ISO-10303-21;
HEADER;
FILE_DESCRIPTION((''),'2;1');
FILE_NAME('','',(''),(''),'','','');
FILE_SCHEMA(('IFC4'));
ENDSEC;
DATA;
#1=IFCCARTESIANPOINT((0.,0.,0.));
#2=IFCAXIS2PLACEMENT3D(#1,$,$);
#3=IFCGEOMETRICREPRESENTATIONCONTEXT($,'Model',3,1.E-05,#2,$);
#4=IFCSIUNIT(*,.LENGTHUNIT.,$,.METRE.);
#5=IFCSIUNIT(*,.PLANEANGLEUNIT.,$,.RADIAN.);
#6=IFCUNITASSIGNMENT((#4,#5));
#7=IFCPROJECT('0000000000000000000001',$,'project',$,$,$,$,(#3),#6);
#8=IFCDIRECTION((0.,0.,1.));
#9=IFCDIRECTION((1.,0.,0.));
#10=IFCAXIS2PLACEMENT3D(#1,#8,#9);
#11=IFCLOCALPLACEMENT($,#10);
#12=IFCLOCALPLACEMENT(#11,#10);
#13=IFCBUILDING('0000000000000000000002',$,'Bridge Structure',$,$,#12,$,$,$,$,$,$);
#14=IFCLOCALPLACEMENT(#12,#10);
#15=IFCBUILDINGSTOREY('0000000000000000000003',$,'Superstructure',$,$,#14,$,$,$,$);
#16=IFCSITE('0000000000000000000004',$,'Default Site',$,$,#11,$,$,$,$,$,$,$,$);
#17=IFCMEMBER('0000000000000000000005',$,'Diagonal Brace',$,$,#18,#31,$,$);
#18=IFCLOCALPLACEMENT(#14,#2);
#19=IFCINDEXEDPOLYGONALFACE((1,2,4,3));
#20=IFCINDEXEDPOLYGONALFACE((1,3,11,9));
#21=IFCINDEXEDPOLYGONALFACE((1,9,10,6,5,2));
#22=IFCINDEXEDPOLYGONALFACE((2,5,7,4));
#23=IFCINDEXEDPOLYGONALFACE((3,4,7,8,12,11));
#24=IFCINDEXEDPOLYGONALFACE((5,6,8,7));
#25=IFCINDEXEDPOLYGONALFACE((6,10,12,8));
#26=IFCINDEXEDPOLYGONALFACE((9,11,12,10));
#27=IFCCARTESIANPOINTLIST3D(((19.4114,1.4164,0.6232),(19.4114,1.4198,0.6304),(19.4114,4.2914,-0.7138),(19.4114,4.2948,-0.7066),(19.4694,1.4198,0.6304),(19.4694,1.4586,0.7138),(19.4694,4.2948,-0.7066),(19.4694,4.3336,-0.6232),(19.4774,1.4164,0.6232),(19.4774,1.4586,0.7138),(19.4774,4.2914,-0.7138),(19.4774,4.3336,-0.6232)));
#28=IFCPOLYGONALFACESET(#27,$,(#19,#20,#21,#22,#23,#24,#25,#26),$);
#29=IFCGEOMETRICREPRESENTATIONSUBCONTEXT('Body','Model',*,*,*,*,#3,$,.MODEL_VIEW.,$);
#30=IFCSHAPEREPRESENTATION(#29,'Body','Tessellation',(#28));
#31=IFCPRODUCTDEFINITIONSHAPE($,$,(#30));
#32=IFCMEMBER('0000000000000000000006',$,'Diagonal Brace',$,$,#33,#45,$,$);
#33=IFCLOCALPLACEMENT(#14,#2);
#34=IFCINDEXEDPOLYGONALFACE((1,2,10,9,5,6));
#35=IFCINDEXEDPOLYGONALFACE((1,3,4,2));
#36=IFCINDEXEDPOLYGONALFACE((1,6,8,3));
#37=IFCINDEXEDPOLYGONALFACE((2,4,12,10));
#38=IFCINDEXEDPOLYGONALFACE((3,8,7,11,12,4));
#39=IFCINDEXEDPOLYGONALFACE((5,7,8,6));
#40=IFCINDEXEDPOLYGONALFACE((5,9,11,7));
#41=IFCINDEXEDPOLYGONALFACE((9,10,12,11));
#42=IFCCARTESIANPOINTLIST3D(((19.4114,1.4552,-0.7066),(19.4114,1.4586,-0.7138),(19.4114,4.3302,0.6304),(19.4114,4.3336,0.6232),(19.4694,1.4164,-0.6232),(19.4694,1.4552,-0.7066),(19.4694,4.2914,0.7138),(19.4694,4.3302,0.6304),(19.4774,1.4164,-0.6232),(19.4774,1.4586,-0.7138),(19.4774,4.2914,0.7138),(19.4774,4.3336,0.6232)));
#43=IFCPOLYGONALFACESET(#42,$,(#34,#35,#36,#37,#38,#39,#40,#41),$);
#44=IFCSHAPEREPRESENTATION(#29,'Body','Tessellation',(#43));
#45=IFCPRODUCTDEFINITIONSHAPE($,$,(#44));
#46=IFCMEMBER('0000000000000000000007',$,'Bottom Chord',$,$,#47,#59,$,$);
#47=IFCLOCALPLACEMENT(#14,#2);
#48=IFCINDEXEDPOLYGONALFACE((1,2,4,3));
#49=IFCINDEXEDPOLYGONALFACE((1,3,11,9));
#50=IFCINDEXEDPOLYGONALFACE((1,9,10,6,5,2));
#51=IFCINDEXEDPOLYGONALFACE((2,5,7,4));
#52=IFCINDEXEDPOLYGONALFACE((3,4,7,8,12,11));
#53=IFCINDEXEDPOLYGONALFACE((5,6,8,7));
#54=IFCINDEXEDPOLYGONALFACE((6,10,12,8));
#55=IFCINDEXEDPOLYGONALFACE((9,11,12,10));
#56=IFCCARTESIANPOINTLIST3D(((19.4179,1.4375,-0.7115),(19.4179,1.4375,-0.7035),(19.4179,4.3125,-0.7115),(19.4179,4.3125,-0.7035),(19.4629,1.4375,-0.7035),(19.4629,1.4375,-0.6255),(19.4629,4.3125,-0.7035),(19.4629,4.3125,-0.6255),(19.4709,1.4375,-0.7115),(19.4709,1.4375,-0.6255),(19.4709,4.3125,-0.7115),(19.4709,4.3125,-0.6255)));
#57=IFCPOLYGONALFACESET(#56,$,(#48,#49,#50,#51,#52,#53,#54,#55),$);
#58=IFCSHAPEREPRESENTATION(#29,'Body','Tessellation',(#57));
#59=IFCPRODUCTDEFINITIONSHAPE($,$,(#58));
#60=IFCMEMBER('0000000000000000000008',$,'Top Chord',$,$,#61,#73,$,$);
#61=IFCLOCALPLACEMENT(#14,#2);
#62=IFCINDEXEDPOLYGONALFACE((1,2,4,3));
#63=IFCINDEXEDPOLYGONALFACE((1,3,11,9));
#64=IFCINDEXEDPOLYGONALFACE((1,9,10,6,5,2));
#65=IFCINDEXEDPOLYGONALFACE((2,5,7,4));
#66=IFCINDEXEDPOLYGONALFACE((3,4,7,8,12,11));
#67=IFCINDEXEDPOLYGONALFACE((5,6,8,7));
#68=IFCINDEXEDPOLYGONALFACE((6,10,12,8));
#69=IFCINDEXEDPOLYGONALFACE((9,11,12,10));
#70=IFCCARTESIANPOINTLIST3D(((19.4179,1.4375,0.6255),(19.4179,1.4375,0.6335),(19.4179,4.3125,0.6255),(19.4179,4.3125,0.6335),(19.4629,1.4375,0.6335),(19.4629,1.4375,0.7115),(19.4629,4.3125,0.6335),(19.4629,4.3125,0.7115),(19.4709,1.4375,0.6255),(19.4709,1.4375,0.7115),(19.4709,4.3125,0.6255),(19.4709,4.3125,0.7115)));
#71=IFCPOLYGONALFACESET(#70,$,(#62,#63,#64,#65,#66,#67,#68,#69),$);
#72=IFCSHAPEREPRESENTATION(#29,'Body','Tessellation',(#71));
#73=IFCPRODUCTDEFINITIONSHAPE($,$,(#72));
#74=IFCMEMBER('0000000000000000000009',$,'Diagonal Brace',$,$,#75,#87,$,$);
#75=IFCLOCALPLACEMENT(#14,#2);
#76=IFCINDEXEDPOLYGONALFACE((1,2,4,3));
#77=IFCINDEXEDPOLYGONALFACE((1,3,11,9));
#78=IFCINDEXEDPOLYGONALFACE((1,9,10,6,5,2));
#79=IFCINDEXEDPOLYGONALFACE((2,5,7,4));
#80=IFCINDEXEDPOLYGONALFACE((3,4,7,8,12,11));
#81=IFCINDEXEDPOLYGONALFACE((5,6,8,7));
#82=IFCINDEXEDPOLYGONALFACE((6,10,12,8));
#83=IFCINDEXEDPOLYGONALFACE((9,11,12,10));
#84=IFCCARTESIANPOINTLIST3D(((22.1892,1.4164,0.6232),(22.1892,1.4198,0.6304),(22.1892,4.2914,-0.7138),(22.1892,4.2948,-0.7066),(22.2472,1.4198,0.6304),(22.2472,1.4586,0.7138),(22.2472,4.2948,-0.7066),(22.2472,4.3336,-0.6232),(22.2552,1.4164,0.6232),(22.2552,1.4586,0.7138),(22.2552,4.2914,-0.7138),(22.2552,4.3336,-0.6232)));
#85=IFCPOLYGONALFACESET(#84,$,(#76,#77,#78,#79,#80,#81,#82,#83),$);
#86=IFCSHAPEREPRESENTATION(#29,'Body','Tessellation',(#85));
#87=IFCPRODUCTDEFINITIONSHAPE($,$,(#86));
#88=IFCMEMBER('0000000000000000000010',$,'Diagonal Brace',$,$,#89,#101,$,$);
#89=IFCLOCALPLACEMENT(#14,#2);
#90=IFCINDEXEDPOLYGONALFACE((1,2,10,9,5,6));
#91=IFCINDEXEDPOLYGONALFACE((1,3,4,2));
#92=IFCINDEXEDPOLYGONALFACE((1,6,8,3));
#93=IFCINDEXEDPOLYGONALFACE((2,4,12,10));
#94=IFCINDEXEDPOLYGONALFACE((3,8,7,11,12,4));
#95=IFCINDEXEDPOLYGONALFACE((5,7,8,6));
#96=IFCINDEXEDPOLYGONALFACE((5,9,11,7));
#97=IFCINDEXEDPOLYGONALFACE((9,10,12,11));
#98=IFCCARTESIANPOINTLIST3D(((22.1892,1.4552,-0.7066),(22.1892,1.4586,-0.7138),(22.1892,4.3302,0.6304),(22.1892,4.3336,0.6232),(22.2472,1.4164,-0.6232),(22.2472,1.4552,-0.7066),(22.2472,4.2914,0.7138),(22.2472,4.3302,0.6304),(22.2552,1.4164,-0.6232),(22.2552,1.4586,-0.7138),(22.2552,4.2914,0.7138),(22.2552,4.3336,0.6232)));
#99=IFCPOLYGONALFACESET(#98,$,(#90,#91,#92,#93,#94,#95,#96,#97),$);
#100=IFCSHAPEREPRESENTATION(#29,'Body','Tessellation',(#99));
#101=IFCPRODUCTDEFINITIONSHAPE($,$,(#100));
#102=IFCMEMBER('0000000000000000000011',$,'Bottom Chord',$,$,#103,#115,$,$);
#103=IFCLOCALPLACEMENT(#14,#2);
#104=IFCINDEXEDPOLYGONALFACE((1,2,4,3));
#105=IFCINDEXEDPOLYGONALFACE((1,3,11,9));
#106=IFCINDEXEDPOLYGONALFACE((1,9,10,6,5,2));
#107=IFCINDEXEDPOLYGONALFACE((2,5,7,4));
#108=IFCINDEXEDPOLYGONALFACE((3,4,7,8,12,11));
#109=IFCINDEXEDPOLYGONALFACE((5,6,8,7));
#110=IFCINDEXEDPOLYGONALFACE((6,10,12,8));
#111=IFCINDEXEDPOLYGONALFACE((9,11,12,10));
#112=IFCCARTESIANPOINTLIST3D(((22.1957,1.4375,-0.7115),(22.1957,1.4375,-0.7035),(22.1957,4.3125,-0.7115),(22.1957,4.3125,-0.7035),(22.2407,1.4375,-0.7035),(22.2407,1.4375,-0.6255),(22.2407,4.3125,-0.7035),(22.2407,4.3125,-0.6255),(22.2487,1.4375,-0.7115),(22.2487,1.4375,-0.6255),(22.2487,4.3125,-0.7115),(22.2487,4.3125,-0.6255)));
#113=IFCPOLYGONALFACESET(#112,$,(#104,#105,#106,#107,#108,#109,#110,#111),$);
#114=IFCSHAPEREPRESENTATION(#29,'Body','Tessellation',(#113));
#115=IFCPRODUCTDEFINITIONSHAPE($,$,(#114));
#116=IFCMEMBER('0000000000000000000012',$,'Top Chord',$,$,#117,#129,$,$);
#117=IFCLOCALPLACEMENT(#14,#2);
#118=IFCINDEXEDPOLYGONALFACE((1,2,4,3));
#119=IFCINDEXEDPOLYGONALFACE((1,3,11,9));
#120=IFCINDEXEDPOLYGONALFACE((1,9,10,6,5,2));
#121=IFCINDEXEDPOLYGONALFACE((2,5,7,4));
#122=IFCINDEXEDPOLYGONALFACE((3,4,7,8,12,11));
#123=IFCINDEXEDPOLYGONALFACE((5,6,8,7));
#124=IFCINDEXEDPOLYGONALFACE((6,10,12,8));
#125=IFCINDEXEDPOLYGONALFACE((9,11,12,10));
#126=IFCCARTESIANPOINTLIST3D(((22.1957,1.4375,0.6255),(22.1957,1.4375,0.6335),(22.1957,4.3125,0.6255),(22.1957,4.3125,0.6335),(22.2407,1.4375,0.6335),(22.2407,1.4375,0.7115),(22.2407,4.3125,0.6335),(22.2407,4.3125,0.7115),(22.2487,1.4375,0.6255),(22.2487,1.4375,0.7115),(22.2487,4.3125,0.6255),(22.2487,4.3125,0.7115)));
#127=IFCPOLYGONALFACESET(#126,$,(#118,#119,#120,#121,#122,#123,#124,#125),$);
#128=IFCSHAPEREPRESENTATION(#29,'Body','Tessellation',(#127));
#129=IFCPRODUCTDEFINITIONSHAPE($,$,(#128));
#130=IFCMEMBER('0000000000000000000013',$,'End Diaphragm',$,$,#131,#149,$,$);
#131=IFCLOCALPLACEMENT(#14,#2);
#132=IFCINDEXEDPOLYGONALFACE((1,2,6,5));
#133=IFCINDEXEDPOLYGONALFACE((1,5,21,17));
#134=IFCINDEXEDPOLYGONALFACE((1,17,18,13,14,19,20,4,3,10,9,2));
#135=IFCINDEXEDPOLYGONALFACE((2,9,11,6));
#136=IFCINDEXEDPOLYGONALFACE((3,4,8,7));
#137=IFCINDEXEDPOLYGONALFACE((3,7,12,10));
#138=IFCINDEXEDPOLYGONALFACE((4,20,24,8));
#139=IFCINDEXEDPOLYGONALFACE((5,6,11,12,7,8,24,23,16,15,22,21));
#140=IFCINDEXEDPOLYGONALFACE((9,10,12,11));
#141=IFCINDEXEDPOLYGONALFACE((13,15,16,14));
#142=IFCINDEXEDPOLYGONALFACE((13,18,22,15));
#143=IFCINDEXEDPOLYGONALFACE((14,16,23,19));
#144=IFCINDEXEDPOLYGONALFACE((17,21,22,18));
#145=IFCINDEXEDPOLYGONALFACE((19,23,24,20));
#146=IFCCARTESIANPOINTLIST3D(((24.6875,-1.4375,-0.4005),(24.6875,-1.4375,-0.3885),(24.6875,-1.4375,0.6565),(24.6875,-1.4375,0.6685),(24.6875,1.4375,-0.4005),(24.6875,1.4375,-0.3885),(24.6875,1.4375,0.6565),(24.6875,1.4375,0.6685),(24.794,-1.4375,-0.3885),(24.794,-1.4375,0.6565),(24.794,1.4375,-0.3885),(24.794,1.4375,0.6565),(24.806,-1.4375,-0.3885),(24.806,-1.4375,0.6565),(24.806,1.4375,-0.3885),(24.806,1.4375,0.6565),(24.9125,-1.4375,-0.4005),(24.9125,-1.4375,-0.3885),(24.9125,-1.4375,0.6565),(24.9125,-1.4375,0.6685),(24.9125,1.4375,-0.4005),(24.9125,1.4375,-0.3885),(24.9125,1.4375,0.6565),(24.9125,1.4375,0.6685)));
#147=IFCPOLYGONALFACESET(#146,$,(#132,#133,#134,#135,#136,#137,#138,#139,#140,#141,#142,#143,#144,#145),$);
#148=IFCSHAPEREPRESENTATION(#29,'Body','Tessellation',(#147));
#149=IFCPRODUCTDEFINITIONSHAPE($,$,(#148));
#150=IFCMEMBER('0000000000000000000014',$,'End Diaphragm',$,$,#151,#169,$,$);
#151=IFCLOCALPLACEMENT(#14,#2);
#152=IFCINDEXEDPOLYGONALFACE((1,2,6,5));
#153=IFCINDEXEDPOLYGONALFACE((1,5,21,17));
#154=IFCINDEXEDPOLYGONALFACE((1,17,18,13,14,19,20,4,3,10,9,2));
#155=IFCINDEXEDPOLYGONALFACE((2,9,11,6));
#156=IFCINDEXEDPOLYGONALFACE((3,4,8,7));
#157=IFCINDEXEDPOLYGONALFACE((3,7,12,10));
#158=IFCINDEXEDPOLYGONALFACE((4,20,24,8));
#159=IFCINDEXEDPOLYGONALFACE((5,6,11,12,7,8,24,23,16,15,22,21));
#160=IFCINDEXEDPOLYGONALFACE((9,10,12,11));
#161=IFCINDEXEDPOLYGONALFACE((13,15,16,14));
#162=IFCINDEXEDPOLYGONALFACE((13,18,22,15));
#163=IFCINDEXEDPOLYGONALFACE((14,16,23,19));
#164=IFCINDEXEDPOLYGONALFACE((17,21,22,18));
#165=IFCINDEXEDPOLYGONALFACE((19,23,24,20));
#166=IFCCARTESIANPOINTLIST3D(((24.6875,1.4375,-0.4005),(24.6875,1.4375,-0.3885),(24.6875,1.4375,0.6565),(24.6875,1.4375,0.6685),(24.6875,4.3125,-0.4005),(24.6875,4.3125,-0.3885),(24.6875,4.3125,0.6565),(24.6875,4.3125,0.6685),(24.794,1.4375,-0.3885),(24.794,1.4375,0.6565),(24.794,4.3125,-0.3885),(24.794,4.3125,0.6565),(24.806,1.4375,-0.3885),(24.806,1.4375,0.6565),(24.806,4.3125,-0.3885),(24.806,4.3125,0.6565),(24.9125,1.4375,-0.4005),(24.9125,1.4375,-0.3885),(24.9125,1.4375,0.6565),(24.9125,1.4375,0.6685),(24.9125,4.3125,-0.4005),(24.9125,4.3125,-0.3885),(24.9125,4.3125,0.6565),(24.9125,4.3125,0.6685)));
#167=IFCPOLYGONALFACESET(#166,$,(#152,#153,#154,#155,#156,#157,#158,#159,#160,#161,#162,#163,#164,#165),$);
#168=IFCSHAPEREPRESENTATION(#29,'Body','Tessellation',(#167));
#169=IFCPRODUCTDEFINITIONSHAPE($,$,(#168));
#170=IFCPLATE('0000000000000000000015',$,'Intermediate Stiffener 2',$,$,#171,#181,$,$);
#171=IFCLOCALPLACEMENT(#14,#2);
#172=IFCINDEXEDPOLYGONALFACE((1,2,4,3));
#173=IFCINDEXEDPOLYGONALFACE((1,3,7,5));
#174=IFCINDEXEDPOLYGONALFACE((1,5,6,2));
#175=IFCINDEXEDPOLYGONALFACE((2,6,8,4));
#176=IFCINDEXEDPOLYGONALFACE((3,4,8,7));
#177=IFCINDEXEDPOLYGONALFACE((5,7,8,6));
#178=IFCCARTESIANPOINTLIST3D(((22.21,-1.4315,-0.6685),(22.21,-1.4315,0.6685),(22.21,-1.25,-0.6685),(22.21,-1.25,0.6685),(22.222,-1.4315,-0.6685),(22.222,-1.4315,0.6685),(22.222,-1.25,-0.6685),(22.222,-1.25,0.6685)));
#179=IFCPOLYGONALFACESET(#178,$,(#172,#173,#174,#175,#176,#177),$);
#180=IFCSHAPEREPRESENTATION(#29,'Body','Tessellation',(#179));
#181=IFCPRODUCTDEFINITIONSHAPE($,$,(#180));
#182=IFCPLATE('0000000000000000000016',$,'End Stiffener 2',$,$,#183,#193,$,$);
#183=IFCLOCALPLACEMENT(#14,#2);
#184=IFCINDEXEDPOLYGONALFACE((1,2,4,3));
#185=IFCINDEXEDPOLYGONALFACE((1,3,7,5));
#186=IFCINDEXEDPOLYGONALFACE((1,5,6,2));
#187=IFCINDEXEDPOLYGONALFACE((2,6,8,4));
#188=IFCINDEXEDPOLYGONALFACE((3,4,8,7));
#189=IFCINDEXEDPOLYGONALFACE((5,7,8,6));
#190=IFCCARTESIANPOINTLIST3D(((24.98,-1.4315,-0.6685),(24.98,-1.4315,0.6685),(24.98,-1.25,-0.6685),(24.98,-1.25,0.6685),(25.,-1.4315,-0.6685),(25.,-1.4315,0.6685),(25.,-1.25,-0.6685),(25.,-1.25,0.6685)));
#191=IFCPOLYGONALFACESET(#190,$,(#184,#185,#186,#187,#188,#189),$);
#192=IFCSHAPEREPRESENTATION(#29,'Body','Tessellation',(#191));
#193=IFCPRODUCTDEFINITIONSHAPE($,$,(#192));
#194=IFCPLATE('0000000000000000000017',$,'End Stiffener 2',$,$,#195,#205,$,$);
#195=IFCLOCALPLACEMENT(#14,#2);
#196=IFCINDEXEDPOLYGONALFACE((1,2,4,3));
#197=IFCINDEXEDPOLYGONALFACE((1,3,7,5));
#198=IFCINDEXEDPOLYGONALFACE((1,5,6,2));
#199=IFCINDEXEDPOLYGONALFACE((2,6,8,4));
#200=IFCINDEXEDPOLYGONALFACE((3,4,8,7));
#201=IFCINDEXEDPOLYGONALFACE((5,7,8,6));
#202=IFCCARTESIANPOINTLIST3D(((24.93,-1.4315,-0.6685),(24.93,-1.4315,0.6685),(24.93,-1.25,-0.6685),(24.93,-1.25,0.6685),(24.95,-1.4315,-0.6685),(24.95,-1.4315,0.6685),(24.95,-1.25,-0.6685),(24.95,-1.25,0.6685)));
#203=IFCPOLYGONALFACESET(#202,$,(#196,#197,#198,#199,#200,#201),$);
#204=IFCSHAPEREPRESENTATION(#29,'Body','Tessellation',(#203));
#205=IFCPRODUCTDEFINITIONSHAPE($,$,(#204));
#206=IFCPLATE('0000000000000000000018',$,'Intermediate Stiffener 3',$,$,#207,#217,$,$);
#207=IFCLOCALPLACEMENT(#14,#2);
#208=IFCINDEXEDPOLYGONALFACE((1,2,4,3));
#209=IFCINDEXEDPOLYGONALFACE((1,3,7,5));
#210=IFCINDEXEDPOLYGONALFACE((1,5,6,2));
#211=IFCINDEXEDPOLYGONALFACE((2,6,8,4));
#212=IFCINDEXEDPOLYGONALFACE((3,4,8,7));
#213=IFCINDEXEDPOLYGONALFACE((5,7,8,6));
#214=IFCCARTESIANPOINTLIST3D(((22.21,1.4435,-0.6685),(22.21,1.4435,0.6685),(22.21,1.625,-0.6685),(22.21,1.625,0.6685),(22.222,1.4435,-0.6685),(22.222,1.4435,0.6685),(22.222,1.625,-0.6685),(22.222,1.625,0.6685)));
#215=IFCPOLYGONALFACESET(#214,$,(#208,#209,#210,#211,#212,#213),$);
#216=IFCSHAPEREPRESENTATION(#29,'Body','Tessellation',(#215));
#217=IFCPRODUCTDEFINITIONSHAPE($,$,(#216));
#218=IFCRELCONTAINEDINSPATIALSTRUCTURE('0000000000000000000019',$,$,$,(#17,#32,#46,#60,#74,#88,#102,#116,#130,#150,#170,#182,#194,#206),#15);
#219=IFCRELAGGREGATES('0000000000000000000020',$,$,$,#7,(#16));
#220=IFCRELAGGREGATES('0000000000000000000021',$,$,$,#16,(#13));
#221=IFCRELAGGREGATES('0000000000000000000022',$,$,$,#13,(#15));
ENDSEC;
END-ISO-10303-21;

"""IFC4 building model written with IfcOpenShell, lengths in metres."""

from ifc_helpers import new_model, si_unit, frame, origin, origin_with_axes, origin_2d_with_axis, place, context, subcontext, project, spatial, rectangle, i_section, l_section, extrude, element, save


model = new_model("IFC4")

# Units and contexts
model_context = context("Model", 3, precision=1e-05, world=origin())
body_context = subcontext(model_context, "Body", "Model", "MODEL_VIEW")
ifc_project = project(units=[si_unit("LENGTHUNIT", "METRE"), si_unit("PLANEANGLEUNIT", "RADIAN")], contexts=[model_context])

# Site, building, storey
site_placement = place(None, origin_with_axes())
site = spatial("IfcSite", under=ifc_project, at=site_placement, Name="Default Site")
building_placement = place(site_placement, origin_with_axes())
building = spatial("IfcBuilding", under=site, at=building_placement, Name="Bridge Structure")
storey_placement = place(building_placement, origin_with_axes())
storey = spatial("IfcBuildingStorey", under=building, at=storey_placement, Name="Superstructure")

# Members
for number, where, z_axis, x_axis, name in (
    (1, (19.4444, 1.4375, 0.6685), (0.0, 0.906746, -0.421676), (-1.0, 0.0, 0.0), "Diagonal Brace"),
    (2, (19.4444, 1.4375, -0.6685), (0.0, 0.906746, 0.421676), (-1.0, 0.0, 0.0), "Diagonal Brace"),
):
    element("IfcMember", number, at=place(storey_placement, frame(where, z_axis=z_axis, x_axis=x_axis)), inside=storey, Name=name, context=body_context, shape_type="SweptSolid", body=[
        extrude(l_section(Depth=0.1, Width=0.066, Thickness=0.008, at=origin_2d_with_axis()), origin_with_axes(), (0.0, 0.0, 1.0), 3.1707),
    ])
for number, where, z_axis, x_axis, name in (
    (3, (19.4444, 1.4375, -0.6685), (0.0, 1.0, 0.0), (-1.0, 0.0, 0.0), "Bottom Chord"),
    (4, (19.4444, 1.4375, 0.6685), (0.0, 1.0, 0.0), (-1.0, 0.0, 0.0), "Top Chord"),
):
    element("IfcMember", number, at=place(storey_placement, frame(where, z_axis=z_axis, x_axis=x_axis)), inside=storey, Name=name, context=body_context, shape_type="SweptSolid", body=[
        extrude(l_section(Depth=0.086, Width=0.053, Thickness=0.008, at=origin_2d_with_axis()), origin_with_axes(), (0.0, 0.0, 1.0), 2.875),
    ])
for number, where, z_axis, x_axis, name in (
    (5, (22.2222, 1.4375, 0.6685), (0.0, 0.906746, -0.421676), (-1.0, 0.0, 0.0), "Diagonal Brace"),
    (6, (22.2222, 1.4375, -0.6685), (0.0, 0.906746, 0.421676), (-1.0, 0.0, 0.0), "Diagonal Brace"),
):
    element("IfcMember", number, at=place(storey_placement, frame(where, z_axis=z_axis, x_axis=x_axis)), inside=storey, Name=name, context=body_context, shape_type="SweptSolid", body=[
        extrude(l_section(Depth=0.1, Width=0.066, Thickness=0.008, at=origin_2d_with_axis()), origin_with_axes(), (0.0, 0.0, 1.0), 3.1707),
    ])
for number, where, z_axis, x_axis, name in (
    (7, (22.2222, 1.4375, -0.6685), (0.0, 1.0, 0.0), (-1.0, 0.0, 0.0), "Bottom Chord"),
    (8, (22.2222, 1.4375, 0.6685), (0.0, 1.0, 0.0), (-1.0, 0.0, 0.0), "Top Chord"),
):
    element("IfcMember", number, at=place(storey_placement, frame(where, z_axis=z_axis, x_axis=x_axis)), inside=storey, Name=name, context=body_context, shape_type="SweptSolid", body=[
        extrude(l_section(Depth=0.086, Width=0.053, Thickness=0.008, at=origin_2d_with_axis()), origin_with_axes(), (0.0, 0.0, 1.0), 2.875),
    ])
for number, where, z_axis, x_axis, name in (
    (9, (24.8, -1.4375, 0.134), (0.0, 1.0, 0.0), (-1.0, 0.0, 0.0), "End Diaphragm"),
    (10, (24.8, 1.4375, 0.134), (0.0, 1.0, 0.0), (-1.0, 0.0, 0.0), "End Diaphragm"),
):
    element("IfcMember", number, at=place(storey_placement, frame(where, z_axis=z_axis, x_axis=x_axis)), inside=storey, Name=name, context=body_context, shape_type="SweptSolid", body=[
        extrude(i_section(OverallWidth=0.225, OverallDepth=1.069, WebThickness=0.012, FlangeThickness=0.012, at=origin_2d_with_axis()), origin_with_axes(), (0.0, 0.0, 1.0), 2.875),
    ])

# Plates
plate_placement = place(storey_placement, frame((22.216, -1.3408, -0.6685), z_axis=(0.0, 0.0, 1.0), x_axis=(1.0, 0.0, 0.0)))
element("IfcPlate", 11, at=plate_placement, inside=storey, Name="Intermediate Stiffener 2", context=body_context, shape_type="SweptSolid", body=[
    extrude(rectangle(XDim=0.012, YDim=0.1815, at=origin_2d_with_axis()), origin_with_axes(), (0.0, 0.0, 1.0), 1.337),
])
for number, where, z_axis, x_axis, name in (
    (12, (24.99, -1.3408, -0.6685), (0.0, 0.0, 1.0), (1.0, 0.0, 0.0), "End Stiffener 2"),
    (13, (24.94, -1.3408, -0.6685), (0.0, 0.0, 1.0), (1.0, 0.0, 0.0), "End Stiffener 2"),
):
    element("IfcPlate", number, at=place(storey_placement, frame(where, z_axis=z_axis, x_axis=x_axis)), inside=storey, Name=name, context=body_context, shape_type="SweptSolid", body=[
        extrude(rectangle(XDim=0.02, YDim=0.1815, at=origin_2d_with_axis()), origin_with_axes(), (0.0, 0.0, 1.0), 1.337),
    ])
for number, where, z_axis, x_axis, name in (
    (14, (22.216, 1.5343, -0.6685), (0.0, 0.0, 1.0), (1.0, 0.0, 0.0), "Intermediate Stiffener 3"),
):
    element("IfcPlate", number, at=place(storey_placement, frame(where, z_axis=z_axis, x_axis=x_axis)), inside=storey, Name=name, context=body_context, shape_type="SweptSolid", body=[
        extrude(rectangle(XDim=0.012, YDim=0.1815, at=origin_2d_with_axis()), origin_with_axes(), (0.0, 0.0, 1.0), 1.337),
    ])

save(model, "model.ifc")
